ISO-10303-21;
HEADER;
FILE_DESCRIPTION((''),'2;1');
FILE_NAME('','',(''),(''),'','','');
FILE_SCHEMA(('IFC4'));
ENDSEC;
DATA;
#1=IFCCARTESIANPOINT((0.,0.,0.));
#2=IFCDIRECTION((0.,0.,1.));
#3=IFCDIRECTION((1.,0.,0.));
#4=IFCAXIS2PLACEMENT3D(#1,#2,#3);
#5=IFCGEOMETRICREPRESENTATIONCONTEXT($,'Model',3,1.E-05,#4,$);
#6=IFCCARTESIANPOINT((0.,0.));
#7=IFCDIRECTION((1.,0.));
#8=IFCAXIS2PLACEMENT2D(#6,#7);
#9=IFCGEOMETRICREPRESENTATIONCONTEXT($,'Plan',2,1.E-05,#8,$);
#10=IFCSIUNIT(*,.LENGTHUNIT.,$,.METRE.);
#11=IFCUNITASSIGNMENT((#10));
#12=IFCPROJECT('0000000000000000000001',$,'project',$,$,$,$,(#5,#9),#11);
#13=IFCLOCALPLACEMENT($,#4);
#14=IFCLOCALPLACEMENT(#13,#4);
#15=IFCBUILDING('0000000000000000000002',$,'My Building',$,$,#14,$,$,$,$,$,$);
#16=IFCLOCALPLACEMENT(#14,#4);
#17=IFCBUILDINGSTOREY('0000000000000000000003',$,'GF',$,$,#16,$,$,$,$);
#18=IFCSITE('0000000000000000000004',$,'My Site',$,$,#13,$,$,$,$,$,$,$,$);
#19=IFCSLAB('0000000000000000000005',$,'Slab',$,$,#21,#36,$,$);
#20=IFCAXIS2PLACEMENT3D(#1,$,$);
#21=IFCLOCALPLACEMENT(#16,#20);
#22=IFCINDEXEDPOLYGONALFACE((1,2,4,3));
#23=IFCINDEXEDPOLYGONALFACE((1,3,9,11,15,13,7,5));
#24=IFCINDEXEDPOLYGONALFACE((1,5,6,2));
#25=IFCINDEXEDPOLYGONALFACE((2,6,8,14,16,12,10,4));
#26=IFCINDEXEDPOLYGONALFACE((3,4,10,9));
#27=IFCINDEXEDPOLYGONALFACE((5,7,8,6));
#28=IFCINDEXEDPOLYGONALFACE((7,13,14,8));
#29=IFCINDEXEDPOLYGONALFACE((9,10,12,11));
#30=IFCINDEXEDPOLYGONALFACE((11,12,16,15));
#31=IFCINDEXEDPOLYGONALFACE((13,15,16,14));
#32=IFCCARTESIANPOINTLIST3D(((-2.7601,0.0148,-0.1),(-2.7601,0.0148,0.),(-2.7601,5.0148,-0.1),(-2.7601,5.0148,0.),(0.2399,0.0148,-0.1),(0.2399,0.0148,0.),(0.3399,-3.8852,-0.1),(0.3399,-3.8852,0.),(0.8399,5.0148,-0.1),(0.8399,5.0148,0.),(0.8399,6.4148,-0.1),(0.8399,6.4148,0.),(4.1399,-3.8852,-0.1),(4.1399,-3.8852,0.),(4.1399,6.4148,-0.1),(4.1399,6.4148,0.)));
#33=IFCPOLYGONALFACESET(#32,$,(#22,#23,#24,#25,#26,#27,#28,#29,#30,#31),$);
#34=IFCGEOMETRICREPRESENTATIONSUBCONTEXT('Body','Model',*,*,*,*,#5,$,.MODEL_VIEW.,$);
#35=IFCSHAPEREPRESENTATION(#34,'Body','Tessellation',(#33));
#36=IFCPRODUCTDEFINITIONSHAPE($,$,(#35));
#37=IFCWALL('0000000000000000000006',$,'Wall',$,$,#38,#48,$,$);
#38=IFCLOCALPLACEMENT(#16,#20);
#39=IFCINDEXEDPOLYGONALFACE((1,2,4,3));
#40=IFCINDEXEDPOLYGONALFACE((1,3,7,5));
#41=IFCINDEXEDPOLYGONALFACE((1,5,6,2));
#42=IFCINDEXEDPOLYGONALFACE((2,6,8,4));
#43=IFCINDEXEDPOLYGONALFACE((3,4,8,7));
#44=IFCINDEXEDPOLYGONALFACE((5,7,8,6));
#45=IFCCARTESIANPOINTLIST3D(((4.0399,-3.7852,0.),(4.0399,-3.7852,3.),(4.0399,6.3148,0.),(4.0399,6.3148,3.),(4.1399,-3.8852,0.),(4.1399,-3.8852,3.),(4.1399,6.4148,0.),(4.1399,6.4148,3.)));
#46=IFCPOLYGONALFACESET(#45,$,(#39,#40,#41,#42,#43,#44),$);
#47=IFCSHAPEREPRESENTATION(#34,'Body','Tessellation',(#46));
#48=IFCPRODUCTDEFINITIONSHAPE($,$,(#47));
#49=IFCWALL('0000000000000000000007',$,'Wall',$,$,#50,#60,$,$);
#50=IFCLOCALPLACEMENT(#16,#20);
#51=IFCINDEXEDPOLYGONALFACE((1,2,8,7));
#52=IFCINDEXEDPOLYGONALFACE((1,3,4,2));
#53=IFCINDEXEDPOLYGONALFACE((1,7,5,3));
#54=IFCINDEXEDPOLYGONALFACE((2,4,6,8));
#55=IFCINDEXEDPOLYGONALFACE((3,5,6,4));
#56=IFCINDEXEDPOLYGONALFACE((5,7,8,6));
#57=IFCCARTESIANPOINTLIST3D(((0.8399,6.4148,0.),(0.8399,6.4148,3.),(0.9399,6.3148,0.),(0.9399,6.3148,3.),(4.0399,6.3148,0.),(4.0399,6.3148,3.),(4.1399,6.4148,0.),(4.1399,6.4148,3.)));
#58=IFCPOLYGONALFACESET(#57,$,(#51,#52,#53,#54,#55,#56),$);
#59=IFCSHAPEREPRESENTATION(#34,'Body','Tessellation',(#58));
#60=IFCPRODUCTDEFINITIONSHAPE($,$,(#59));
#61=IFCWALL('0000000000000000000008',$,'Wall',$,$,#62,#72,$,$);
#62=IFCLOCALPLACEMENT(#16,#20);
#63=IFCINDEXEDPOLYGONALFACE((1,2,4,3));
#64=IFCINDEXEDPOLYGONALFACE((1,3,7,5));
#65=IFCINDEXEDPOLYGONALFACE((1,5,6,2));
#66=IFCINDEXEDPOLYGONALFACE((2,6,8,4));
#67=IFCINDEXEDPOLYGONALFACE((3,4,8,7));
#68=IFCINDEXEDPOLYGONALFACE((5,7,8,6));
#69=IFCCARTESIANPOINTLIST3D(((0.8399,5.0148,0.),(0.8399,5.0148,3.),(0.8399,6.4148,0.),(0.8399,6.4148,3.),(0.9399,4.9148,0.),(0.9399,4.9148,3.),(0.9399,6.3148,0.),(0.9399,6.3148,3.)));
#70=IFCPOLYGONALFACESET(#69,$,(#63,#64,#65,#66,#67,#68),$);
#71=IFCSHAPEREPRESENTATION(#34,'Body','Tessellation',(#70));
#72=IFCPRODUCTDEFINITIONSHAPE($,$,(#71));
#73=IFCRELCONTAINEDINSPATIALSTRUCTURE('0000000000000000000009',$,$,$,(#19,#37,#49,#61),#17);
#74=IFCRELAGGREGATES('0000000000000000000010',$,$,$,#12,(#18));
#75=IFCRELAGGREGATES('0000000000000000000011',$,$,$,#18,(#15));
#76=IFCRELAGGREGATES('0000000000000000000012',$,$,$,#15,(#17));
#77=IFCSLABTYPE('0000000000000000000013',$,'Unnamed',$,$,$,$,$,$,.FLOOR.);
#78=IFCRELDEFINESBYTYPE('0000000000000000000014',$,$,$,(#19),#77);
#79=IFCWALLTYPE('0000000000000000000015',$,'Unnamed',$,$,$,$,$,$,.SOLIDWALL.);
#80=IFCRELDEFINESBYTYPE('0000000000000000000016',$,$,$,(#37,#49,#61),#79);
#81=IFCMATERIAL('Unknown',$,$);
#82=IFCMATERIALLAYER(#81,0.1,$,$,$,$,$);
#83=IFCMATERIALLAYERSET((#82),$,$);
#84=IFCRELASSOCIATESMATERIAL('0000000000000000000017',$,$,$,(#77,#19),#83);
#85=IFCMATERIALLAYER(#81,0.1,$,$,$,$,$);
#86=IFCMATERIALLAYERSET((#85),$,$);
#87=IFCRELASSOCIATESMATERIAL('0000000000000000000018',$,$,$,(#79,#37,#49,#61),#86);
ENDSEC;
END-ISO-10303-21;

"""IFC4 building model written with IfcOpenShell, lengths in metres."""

from ifc_helpers import new_model, si_unit, frame, origin_with_axes, origin_2d_with_axis, place, context, subcontext, project, spatial, line, indexed_curve, outline, extrude, material, layer, layer_set, layer_usage, type_object, element, save


model = new_model("IFC4")

# Units and contexts
model_context = context("Model", 3, precision=1e-05, world=origin_with_axes())
plan_context = context("Plan", 2, precision=1e-05, world=origin_2d_with_axis())
body_context_1 = subcontext(model_context, "Body", "Model", "MODEL_VIEW")
ifc_project = project(units=[si_unit("LENGTHUNIT", "METRE")], contexts=[model_context, plan_context])

# Site, building, storey
site_placement = place(None, origin_with_axes())
site = spatial("IfcSite", under=ifc_project, at=site_placement, Name="My Site")
building_placement = place(site_placement, origin_with_axes())
building = spatial("IfcBuilding", under=site, at=building_placement, Name="My Building")
storey_placement = place(building_placement, origin_with_axes())
storey = spatial("IfcBuildingStorey", under=building, at=storey_placement, Name="GF")

# Slab
ifc_material = material(Name="Unknown")
ifc_layer_1 = layer(ifc_material, 0.1)
ifc_layer_set_1 = layer_set([ifc_layer_1])
ifc_layer_usage_1 = layer_usage(ifc_layer_set_1, "AXIS3", "POSITIVE", -0.1)
slab_type = type_object("IfcSlabType", Name="Unnamed", PredefinedType="FLOOR", material=ifc_layer_set_1)
slab_placement = place(storey_placement, frame((4.1399, -3.8852, 0.0), z_axis=(0.0, 0.0, 1.0), x_axis=(1.0, 0.0, 0.0)))
element("IfcSlab", 1, at=slab_placement, inside=storey, type_object=slab_type, material=ifc_layer_usage_1, Name="Slab", context=body_context_1, shape_type="SweptSolid", body=[
    extrude(outline(indexed_curve([(0.0, 0.0), (0.0, 10.3), (-3.3, 10.3), (-3.3, 8.9), (-6.9, 8.9), (-6.9, 3.9), (-3.9, 3.9), (-3.8, 0.0), (0.0, 0.0)])), frame((0.0, 0.0, -0.1), z_axis=(0.0, 0.0, 1.0), x_axis=(1.0, 0.0, 0.0)), (0.0, 0.0, 1.0), 0.1),
])

# Shared definitions
ifc_layer_2 = layer(ifc_material, 0.1)
ifc_layer_set_2 = layer_set([ifc_layer_2])
wall_type = type_object("IfcWallType", Name="Unnamed", PredefinedType="SOLIDWALL", material=ifc_layer_set_2)

# Walls
ifc_layer_usage_2 = layer_usage(ifc_layer_set_2, "AXIS2", "POSITIVE", 0.0)
wall_1_placement = place(storey_placement, frame((4.1399, -3.8852, 0.0), z_axis=(0.0, 0.0, 1.0), x_axis=(0.0, 1.0, 0.0)))
element("IfcWall", 2, at=wall_1_placement, inside=storey, type_object=wall_type, material=ifc_layer_usage_2, Name="Wall", context=body_context_1, shape_type="SweptSolid", body=[
    extrude(outline(indexed_curve([(0.0, 0.0), (0.1, 0.1), (10.2, 0.1), (10.3, 0.0)], segments=[line(1, 2, 3, 4, 1)])), origin_with_axes(), (0.0, 0.0, 1.0), 3.0),
])
ifc_layer_usage_3 = layer_usage(ifc_layer_set_2, "AXIS2", "POSITIVE", 0.0)
wall_2_placement = place(storey_placement, frame((4.1399, 6.4148, 0.0), z_axis=(0.0, 0.0, 1.0), x_axis=(-1.0, 0.0, 0.0)))
element("IfcWall", 3, at=wall_2_placement, inside=storey, type_object=wall_type, material=ifc_layer_usage_3, Name="Wall", context=body_context_1, shape_type="SweptSolid", body=[
    extrude(outline(indexed_curve([(0.0, 0.0), (0.1, 0.1), (3.2, 0.1), (3.3, 0.0)], segments=[line(1, 2, 3, 4, 1)])), origin_with_axes(), (0.0, 0.0, 1.0), 3.0),
])
ifc_layer_usage_4 = layer_usage(ifc_layer_set_2, "AXIS2", "POSITIVE", 0.0)
wall_3_placement = place(storey_placement, frame((0.8399, 6.4148, 0.0), z_axis=(0.0, 0.0, 1.0), x_axis=(0.0, -1.0, 0.0)))
element("IfcWall", 4, at=wall_3_placement, inside=storey, type_object=wall_type, material=ifc_layer_usage_4, Name="Wall", context=body_context_1, shape_type="SweptSolid", body=[
    extrude(outline(indexed_curve([(0.0, 0.0), (0.1, 0.1), (1.5, 0.1), (1.4, 0.0)], segments=[line(1, 2, 3, 4, 1)])), origin_with_axes(), (0.0, 0.0, 1.0), 3.0),
])

save(model, "model.ifc")
